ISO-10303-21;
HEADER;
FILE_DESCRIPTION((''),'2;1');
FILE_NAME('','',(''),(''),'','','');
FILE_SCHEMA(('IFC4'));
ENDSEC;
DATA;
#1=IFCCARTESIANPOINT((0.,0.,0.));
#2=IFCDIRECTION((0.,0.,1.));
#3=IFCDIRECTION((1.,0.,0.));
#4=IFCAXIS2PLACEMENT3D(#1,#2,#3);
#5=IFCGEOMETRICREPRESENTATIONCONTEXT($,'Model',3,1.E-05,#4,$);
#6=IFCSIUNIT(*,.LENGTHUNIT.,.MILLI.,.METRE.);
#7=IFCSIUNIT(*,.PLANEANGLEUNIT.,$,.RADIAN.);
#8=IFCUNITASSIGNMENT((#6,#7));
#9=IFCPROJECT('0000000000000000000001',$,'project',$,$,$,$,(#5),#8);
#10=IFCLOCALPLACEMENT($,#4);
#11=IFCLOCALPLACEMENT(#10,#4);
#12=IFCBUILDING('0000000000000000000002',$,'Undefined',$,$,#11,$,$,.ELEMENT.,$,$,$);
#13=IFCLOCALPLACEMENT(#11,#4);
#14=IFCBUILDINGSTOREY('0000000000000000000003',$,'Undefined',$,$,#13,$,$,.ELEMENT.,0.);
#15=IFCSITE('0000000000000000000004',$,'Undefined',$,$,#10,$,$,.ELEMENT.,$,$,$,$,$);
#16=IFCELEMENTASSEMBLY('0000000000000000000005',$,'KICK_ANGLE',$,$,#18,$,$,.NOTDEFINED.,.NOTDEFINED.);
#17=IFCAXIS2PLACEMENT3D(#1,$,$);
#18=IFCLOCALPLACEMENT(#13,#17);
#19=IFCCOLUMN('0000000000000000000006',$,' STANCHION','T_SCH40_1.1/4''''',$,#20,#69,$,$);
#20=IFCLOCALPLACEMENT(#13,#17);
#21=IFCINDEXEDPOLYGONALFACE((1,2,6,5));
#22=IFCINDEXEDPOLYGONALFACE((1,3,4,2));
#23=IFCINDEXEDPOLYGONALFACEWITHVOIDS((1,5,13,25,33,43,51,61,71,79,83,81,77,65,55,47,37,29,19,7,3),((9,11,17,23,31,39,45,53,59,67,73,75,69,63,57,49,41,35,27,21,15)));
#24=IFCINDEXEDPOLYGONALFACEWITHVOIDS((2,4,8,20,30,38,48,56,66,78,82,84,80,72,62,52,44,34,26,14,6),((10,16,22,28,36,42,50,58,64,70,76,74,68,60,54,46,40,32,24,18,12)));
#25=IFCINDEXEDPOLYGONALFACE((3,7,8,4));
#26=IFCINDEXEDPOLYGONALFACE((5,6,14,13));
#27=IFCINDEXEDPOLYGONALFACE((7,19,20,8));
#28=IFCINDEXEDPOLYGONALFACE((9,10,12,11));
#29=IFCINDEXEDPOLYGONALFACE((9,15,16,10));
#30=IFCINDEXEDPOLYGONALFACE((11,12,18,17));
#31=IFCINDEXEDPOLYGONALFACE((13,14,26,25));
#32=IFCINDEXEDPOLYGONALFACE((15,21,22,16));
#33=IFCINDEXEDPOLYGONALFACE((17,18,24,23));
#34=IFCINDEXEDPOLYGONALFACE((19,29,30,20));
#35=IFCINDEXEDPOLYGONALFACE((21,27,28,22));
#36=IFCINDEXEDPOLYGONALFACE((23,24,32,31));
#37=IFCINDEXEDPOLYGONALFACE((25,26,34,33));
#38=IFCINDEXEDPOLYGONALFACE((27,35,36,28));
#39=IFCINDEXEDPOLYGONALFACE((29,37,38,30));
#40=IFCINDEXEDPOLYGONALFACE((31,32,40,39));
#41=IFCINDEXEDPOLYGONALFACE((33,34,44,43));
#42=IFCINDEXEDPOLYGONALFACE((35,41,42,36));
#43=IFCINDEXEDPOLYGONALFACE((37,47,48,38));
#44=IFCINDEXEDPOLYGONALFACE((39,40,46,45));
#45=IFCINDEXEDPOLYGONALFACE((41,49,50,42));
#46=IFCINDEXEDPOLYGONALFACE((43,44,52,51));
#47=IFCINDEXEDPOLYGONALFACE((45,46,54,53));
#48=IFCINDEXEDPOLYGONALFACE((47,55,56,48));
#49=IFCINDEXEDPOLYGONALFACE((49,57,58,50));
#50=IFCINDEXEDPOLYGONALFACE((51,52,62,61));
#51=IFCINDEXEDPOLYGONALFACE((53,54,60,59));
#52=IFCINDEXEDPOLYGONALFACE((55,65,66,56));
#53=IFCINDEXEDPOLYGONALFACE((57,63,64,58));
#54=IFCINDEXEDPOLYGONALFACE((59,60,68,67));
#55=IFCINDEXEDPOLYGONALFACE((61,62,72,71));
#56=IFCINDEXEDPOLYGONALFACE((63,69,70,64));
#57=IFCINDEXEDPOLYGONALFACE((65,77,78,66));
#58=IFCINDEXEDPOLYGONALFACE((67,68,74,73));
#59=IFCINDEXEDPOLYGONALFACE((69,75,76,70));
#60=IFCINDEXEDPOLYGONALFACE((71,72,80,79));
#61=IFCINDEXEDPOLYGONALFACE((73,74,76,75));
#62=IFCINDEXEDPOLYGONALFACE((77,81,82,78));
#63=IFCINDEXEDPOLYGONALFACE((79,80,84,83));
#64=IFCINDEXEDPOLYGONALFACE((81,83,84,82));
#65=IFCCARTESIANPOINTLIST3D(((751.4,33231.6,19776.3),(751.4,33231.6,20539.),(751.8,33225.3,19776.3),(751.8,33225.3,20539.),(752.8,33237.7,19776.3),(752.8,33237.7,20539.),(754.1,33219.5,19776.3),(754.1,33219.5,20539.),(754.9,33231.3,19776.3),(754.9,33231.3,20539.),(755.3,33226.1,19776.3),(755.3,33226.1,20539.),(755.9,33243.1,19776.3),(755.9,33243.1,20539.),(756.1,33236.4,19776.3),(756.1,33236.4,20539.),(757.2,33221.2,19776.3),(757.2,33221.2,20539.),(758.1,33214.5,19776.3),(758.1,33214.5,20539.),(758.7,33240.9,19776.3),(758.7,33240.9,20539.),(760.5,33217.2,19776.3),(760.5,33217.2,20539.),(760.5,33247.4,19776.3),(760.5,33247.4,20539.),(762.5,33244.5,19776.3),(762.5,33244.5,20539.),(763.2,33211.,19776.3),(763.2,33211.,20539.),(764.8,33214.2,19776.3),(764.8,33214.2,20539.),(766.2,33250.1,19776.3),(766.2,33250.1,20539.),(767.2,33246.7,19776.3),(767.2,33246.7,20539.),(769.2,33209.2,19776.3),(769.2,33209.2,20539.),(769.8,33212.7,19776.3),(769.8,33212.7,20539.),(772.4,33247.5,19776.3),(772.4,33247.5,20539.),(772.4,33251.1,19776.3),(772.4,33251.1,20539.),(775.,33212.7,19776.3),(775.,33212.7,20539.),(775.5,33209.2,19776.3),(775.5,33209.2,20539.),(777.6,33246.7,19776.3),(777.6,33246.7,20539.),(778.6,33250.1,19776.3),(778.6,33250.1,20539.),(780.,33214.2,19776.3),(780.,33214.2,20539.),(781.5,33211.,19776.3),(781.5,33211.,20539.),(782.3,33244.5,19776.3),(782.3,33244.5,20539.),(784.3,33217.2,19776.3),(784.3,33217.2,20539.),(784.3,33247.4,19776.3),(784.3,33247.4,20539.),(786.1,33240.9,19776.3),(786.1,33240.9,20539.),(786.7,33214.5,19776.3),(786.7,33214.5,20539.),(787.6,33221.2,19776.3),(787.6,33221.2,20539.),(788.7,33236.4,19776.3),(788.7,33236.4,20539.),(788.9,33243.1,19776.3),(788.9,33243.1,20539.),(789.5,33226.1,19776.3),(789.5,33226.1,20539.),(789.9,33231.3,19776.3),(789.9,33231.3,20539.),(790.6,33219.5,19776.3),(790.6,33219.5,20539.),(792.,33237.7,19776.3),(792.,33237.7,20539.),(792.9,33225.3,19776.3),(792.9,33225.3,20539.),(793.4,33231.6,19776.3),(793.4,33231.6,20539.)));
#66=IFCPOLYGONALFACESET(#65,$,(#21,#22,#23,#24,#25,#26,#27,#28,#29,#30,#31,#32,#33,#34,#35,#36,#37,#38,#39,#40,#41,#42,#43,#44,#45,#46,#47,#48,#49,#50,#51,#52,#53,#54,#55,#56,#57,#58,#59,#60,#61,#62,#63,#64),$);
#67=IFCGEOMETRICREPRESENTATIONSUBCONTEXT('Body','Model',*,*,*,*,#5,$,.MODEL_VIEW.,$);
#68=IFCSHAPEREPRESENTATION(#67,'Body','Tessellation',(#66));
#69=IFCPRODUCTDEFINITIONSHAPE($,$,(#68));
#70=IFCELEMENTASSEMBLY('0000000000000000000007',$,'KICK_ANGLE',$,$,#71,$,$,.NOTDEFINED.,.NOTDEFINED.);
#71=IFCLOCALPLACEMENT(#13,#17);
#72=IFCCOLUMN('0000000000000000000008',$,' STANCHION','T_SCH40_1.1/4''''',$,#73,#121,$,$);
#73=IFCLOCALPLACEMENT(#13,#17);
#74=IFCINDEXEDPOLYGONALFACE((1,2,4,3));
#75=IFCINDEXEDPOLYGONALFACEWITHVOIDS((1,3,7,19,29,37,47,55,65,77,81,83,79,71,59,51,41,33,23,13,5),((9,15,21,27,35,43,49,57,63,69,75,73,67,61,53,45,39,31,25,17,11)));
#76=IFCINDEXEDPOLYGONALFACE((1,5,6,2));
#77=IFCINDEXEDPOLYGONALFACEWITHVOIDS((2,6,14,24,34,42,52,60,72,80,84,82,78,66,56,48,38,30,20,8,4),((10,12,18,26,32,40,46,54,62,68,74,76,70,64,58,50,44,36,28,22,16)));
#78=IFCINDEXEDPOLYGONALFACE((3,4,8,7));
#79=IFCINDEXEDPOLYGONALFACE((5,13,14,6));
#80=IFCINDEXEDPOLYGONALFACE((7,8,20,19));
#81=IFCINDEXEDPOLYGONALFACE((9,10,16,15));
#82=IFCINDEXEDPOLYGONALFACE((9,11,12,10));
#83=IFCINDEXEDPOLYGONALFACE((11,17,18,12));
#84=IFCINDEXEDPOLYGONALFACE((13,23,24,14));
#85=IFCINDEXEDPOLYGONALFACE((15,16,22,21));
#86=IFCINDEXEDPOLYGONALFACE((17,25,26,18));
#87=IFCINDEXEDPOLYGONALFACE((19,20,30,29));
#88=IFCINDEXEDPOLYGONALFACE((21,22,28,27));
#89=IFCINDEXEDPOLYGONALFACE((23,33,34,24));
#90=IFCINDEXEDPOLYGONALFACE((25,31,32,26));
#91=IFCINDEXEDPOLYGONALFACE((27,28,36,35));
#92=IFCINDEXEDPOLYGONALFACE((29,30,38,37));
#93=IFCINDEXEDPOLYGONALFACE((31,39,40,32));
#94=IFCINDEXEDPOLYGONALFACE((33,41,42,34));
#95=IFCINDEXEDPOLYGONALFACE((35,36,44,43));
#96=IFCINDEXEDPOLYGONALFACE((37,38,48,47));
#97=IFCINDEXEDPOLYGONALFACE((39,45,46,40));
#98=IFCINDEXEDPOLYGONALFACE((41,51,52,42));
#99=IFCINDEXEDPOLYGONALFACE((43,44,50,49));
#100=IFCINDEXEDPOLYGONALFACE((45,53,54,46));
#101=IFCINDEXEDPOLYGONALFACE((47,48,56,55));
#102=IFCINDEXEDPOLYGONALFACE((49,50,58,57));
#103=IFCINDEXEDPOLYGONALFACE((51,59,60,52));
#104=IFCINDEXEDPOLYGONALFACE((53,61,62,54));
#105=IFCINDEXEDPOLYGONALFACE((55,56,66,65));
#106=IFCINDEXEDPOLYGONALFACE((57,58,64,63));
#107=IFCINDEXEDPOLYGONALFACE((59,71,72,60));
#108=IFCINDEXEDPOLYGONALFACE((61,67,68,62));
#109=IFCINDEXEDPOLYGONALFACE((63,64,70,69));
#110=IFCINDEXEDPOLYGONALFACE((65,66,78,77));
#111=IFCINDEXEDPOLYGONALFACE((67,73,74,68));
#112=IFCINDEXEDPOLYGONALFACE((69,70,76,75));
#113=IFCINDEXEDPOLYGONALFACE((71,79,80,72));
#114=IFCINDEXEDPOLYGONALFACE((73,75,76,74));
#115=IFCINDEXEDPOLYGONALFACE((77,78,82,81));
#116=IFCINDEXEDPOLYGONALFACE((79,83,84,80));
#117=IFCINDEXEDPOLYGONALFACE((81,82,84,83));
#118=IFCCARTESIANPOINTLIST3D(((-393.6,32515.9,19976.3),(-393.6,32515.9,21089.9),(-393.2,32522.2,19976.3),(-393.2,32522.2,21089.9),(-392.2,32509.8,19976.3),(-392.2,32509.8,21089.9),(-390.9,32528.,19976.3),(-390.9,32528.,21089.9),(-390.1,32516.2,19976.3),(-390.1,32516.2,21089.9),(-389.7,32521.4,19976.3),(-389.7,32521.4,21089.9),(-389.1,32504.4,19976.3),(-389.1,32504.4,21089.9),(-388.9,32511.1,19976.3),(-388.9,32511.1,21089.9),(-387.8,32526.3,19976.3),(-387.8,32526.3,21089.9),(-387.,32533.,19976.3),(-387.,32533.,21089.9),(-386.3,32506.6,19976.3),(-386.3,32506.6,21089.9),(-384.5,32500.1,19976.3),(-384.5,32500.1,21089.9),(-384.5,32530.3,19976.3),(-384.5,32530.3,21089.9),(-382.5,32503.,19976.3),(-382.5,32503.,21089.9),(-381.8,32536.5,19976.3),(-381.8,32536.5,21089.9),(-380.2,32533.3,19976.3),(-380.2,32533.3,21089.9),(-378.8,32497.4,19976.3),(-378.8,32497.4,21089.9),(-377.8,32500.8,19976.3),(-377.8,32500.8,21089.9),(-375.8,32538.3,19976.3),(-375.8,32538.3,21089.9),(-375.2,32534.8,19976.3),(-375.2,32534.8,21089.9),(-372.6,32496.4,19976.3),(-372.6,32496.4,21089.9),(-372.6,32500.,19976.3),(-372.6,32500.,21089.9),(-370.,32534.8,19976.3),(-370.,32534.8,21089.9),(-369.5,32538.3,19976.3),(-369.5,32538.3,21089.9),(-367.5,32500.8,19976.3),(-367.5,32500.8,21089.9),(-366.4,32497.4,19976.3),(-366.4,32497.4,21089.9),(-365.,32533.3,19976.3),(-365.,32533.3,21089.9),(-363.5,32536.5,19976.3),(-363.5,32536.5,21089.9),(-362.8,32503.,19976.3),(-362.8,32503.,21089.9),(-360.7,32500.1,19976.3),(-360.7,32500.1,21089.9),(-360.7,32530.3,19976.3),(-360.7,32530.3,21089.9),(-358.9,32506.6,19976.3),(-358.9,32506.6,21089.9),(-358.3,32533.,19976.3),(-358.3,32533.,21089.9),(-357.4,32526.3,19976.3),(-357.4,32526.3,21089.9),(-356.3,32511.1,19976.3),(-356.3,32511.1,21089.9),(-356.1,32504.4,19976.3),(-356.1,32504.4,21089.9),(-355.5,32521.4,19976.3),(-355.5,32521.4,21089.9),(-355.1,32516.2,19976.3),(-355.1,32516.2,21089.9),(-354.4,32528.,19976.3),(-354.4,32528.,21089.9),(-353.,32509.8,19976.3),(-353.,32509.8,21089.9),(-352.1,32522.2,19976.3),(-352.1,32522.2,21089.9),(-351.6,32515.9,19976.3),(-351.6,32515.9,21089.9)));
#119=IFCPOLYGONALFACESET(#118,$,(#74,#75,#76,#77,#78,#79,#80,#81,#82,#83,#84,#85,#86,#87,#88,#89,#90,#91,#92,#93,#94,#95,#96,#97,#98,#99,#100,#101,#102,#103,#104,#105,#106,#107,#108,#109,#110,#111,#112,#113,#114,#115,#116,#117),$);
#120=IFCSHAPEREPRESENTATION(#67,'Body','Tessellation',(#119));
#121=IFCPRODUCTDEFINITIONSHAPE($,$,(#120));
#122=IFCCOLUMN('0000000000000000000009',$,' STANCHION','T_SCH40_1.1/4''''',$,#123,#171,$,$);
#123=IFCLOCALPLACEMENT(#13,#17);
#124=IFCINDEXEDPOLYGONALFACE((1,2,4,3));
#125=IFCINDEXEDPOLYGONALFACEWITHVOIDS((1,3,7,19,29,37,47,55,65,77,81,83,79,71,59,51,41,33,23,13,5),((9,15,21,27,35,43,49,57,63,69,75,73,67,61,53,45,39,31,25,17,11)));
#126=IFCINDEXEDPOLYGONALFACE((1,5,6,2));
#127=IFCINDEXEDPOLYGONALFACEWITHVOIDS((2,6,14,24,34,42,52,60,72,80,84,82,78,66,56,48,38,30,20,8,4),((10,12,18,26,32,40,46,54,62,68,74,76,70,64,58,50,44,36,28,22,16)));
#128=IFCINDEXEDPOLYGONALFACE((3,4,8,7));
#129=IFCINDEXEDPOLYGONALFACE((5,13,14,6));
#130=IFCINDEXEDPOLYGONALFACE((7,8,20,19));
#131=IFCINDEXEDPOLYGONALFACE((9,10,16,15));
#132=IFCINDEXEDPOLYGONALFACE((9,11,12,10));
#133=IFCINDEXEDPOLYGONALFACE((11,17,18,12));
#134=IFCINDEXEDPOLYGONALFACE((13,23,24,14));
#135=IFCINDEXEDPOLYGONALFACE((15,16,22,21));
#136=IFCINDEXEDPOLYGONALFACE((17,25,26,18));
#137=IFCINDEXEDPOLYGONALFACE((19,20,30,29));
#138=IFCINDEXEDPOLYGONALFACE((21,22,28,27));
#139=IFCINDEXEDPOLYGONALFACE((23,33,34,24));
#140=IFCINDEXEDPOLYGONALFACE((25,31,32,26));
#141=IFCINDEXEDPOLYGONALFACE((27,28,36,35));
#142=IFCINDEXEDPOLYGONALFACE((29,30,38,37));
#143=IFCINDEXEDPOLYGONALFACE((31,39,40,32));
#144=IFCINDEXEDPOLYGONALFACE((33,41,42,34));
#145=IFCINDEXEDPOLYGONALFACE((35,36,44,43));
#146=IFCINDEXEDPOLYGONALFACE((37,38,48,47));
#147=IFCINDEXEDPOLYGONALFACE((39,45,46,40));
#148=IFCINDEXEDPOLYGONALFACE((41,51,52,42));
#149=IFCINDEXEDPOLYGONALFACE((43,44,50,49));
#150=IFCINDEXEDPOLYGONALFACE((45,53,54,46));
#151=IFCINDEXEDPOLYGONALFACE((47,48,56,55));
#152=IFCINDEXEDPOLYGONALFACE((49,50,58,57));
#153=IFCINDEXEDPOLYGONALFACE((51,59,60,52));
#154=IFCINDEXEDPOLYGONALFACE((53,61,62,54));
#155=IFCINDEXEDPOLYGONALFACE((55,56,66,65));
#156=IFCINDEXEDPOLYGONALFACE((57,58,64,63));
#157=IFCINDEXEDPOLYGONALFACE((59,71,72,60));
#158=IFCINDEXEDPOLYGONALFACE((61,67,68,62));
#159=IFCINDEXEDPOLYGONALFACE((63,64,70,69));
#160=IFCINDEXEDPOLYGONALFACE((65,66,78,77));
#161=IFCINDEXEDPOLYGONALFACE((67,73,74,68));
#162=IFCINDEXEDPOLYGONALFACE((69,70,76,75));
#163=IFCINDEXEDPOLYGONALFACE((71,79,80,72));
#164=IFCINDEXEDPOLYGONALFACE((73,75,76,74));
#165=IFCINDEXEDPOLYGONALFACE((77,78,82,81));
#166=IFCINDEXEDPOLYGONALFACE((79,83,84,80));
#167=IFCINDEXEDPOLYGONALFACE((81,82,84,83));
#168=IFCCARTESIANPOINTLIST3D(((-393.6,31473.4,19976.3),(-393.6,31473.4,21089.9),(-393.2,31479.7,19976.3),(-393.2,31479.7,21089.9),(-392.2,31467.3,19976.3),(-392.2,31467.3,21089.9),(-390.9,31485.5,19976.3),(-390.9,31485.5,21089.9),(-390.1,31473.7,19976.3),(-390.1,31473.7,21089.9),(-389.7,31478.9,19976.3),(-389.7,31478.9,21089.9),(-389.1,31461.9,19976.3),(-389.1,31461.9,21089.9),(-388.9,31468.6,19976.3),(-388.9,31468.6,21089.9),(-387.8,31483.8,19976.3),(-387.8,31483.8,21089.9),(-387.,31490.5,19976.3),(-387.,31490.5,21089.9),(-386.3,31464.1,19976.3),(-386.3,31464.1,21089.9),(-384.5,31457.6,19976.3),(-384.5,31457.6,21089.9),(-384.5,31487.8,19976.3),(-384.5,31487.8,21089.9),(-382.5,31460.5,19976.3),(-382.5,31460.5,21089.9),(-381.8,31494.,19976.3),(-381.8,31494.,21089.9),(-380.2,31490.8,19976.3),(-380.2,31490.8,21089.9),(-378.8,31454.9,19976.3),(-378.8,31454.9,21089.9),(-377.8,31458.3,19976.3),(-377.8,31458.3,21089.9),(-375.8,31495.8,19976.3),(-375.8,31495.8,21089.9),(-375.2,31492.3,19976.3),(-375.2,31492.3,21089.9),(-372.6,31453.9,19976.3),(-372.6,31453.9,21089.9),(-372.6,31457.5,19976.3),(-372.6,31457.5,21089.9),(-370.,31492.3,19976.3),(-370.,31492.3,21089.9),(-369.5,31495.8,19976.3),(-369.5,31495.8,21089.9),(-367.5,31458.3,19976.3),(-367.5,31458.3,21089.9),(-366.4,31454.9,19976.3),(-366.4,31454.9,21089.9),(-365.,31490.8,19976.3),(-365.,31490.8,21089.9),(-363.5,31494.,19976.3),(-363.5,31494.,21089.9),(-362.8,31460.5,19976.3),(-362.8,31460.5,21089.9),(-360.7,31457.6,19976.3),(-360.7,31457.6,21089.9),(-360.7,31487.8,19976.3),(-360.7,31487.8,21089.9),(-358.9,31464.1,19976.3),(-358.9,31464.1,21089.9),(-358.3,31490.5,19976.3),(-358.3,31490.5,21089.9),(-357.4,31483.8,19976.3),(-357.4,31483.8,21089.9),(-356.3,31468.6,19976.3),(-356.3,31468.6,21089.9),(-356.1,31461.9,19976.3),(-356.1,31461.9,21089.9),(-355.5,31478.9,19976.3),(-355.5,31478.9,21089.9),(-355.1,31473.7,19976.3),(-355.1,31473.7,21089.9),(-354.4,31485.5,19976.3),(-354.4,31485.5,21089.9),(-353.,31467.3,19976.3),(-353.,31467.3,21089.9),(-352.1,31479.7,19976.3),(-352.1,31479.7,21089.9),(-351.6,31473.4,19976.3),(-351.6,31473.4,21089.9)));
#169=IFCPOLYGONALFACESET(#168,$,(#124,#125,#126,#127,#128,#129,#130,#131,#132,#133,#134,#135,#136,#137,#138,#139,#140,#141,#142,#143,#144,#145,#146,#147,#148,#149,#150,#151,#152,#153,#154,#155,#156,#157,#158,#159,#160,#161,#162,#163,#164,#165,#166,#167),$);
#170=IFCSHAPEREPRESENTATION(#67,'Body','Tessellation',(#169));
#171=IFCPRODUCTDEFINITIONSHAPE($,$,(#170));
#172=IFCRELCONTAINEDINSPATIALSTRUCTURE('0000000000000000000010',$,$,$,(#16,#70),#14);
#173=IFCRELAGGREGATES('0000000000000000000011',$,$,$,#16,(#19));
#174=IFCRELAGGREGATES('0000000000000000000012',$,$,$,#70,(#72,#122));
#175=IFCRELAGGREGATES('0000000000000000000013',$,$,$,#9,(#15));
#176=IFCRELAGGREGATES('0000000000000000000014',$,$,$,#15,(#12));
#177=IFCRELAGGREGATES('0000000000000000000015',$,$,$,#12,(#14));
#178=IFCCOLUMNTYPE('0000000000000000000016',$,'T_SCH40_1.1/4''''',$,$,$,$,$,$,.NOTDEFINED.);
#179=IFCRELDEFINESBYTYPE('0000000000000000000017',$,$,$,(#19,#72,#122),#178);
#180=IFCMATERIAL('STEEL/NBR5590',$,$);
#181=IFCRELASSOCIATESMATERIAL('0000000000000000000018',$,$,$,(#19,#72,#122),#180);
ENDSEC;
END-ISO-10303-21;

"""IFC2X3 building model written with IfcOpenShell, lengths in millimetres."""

from ifc_helpers import new_model, si_unit, frame, origin_with_axes, origin_2d_with_axis, place, context, subcontext, project, spatial, hollow_circle, extrude, clip, halfspace, material, type_object, element, aggregate, save


model = new_model("IFC2X3")

# Units and contexts
model_context = context("Model", 3, precision=1e-05, world=origin_with_axes())
body_context = subcontext(model_context, "Body", "Model", "MODEL_VIEW")
ifc_project = project(units=[si_unit("LENGTHUNIT", "METRE", prefix="MILLI"), si_unit("PLANEANGLEUNIT", "RADIAN")], contexts=[model_context])

# Site, building, storey
site_placement = place(None, origin_with_axes())
site = spatial("IfcSite", under=ifc_project, at=site_placement, Name="Undefined", CompositionType="ELEMENT")
building_placement = place(site_placement, origin_with_axes())
building = spatial("IfcBuilding", under=site, at=building_placement, Name="Undefined", CompositionType="ELEMENT")
storey_placement = place(building_placement, origin_with_axes())
storey = spatial("IfcBuildingStorey", under=building, at=storey_placement, Name="Undefined", CompositionType="ELEMENT", Elevation=0.0)

# Element assembly, column
assembly_1_placement = place(storey_placement, origin_with_axes())
assembly_1 = element("IfcElementAssembly", 1, at=assembly_1_placement, inside=storey, Name="KICK_ANGLE", AssemblyPlace="NOTDEFINED", PredefinedType="NOTDEFINED")
ifc_material_1 = material(Name="STEEL/NBR5590")
column_type = type_object("IfcColumnType", Name="T_SCH40_1.1/4''", PredefinedType="NOTDEFINED")
column_1_placement = place(assembly_1_placement, frame((772.4, 33230.0, 19776.3), z_axis=(0.0, 0.0, 1.0), x_axis=(1.0, 0.0, 0.0)))
column_1 = element("IfcColumn", 2, at=column_1_placement, type_object=column_type, material=ifc_material_1, Name=" STANCHION", Description="T_SCH40_1.1/4''", context=body_context, shape_type="Clipping", body=[
    clip(extrude(hollow_circle(Radius=21.1, WallThickness=3.6, at=origin_2d_with_axis()), frame((0.0, 0.0, 1113.6), z_axis=(0.0, 0.0, -1.0), x_axis=(0.0, 1.0, 0.0)), (0.0, 0.0, 1.0), 1113.6), halfspace(frame((0.0, 0.0, 762.7), z_axis=(0.0, 0.0, 1.0), x_axis=(0.0, 1.0, 0.0)), False)),
])

# Element assembly, columns
assembly_2_placement = place(storey_placement, origin_with_axes())
assembly_2 = element("IfcElementAssembly", 3, at=assembly_2_placement, inside=storey, Name="KICK_ANGLE", AssemblyPlace="NOTDEFINED", PredefinedType="NOTDEFINED")
column_2_placement = place(assembly_2_placement, frame((-372.6, 32517.5, 19976.3), z_axis=(0.0, 0.0, 1.0), x_axis=(-1.0, 0.0, 0.0)))
column_2 = element("IfcColumn", 4, at=column_2_placement, type_object=column_type, material=ifc_material_1, Name=" STANCHION", Description="T_SCH40_1.1/4''", context=body_context, shape_type="SweptSolid", body=[
    extrude(hollow_circle(Radius=21.1, WallThickness=3.6, at=origin_2d_with_axis()), frame((0.0, 0.0, 1113.6), z_axis=(0.0, 0.0, -1.0), x_axis=(0.0, 1.0, 0.0)), (0.0, 0.0, 1.0), 1113.6),
])
column_3_placement = place(assembly_2_placement, frame((-372.6, 31475.0, 19976.3), z_axis=(0.0, 0.0, 1.0), x_axis=(-1.0, 0.0, 0.0)))
column_3 = element("IfcColumn", 5, at=column_3_placement, type_object=column_type, material=ifc_material_1, Name=" STANCHION", Description="T_SCH40_1.1/4''", context=body_context, shape_type="SweptSolid", body=[
    extrude(hollow_circle(Radius=21.1, WallThickness=3.6, at=origin_2d_with_axis()), frame((0.0, 0.0, 1113.6), z_axis=(0.0, 0.0, -1.0), x_axis=(0.0, 1.0, 0.0)), (0.0, 0.0, 1.0), 1113.6),
])

aggregate(assembly_1, [column_1])
aggregate(assembly_2, [column_2, column_3])

save(model, "model.ifc")
